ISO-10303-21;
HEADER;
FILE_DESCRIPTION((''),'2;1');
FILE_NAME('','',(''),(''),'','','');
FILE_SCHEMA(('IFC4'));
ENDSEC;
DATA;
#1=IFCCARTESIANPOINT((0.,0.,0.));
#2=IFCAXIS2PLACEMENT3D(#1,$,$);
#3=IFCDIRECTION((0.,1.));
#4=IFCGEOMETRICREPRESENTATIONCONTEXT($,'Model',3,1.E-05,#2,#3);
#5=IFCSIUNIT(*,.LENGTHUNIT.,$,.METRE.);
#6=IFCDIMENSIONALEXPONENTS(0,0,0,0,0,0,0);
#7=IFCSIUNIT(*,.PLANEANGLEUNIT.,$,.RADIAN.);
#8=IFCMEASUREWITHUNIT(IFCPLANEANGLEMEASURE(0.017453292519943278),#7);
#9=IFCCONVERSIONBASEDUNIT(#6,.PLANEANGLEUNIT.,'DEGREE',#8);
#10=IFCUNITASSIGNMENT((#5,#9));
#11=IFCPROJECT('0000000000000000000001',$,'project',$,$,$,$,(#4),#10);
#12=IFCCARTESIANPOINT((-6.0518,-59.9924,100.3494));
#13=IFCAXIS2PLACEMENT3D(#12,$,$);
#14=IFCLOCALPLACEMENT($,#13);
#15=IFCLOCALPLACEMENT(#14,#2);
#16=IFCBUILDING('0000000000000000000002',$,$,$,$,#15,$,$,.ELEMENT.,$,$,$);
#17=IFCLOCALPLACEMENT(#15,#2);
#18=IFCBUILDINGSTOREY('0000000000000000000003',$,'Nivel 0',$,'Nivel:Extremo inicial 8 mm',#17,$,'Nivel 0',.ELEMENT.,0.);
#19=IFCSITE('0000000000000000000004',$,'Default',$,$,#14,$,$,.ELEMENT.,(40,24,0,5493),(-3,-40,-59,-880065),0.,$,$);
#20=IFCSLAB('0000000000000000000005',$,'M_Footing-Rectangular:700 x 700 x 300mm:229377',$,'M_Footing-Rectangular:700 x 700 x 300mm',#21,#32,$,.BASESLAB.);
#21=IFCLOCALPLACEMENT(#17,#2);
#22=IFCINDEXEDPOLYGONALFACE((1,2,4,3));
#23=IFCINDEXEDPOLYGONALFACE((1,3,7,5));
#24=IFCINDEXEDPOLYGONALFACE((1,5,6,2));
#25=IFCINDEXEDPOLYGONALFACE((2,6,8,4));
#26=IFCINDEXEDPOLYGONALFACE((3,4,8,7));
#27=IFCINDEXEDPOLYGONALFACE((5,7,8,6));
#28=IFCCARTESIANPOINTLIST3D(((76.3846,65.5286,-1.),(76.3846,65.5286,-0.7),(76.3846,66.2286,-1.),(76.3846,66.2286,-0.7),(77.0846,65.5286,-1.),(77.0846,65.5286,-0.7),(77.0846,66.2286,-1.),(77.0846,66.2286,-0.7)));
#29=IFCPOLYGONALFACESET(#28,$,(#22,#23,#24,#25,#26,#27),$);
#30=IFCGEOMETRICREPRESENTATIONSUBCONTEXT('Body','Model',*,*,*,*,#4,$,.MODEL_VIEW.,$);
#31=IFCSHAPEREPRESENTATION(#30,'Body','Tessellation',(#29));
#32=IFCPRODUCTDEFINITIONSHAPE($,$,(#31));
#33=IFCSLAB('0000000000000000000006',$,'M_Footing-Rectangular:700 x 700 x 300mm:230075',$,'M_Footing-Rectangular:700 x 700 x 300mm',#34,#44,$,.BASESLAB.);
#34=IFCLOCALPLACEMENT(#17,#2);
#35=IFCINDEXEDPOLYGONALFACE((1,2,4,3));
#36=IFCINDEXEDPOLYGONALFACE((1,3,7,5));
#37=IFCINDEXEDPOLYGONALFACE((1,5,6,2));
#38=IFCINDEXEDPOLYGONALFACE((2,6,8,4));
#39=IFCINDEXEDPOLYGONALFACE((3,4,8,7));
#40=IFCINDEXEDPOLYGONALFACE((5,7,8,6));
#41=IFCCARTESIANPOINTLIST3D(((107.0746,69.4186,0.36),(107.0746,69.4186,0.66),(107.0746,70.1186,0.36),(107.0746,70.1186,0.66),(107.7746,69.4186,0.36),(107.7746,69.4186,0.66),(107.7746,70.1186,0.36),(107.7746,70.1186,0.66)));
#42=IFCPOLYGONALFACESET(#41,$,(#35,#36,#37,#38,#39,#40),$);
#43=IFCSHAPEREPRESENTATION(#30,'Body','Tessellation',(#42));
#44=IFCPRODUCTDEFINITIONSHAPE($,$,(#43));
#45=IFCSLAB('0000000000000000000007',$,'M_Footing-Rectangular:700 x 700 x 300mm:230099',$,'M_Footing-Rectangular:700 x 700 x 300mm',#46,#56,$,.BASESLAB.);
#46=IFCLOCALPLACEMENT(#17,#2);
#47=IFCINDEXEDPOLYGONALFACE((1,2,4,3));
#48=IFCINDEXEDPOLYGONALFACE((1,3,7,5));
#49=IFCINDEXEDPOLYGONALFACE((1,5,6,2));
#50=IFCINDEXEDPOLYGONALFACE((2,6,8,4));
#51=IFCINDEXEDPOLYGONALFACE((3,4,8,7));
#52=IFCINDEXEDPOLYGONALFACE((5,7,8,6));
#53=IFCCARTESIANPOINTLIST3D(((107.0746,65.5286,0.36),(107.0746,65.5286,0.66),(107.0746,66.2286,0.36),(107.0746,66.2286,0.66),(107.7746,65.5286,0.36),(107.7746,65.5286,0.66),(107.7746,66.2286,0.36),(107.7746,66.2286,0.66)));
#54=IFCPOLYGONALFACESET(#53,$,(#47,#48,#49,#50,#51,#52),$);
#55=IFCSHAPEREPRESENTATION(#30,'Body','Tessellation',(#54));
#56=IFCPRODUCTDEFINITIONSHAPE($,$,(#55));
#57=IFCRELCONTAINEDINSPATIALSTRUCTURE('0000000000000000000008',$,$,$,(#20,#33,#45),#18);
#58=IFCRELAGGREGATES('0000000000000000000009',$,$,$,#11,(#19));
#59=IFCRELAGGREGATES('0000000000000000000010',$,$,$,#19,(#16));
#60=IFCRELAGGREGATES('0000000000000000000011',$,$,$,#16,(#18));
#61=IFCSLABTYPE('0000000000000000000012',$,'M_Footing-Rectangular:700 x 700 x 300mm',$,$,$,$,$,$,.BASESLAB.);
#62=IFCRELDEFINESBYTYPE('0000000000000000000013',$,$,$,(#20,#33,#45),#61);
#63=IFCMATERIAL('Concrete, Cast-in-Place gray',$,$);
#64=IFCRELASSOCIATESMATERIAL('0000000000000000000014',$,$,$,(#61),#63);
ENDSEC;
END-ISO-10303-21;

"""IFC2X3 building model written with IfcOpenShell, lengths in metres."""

from ifc_helpers import new_model, entity, si_unit, converted_unit, direction, frame, frame_2d, origin, place, context, subcontext, project, spatial, rectangle, extrude, material, type_object, element, save


model = new_model("IFC2X3")

# Units and contexts
model_context = context("Model", 3, precision=1e-05, world=origin(), true_north=direction((0.0, 1.0)))
body_context = subcontext(model_context, "Body", "Model", "MODEL_VIEW")
ifc_project = project(units=[si_unit("LENGTHUNIT", "METRE"), converted_unit("PLANEANGLEUNIT", "DEGREE", entity("IfcPlaneAngleMeasure", 0.017453292519943278), si_unit("PLANEANGLEUNIT", "RADIAN"), dimensions=[0, 0, 0, 0, 0, 0, 0])], contexts=[model_context])

# Site, building, storey
site_placement = place(None, frame((-6.0518, -59.9924, 100.3494)))
site = spatial("IfcSite", under=ifc_project, at=site_placement, Name="Default", CompositionType="ELEMENT", RefLatitude=(40, 24, 0, 5493), RefLongitude=(-3, -40, -59, -880065), RefElevation=0.0)
building_placement = place(site_placement, origin())
building = spatial("IfcBuilding", under=site, at=building_placement, CompositionType="ELEMENT")
storey_placement = place(building_placement, origin())
storey = spatial("IfcBuildingStorey", under=building, at=storey_placement, Name="Nivel 0", ObjectType="Nivel:Extremo inicial 8 mm", LongName="Nivel 0", CompositionType="ELEMENT", Elevation=0.0)

# Shared definitions
ifc_material = material(Name="Concrete, Cast-in-Place gray")

# Slabs
slab_type_1 = type_object("IfcSlabType", Name="M_Footing-Rectangular:700 x 700 x 300mm", PredefinedType="BASESLAB", material=ifc_material)
slab_1_placement = place(storey_placement, origin())
element("IfcSlab", 1, at=slab_1_placement, inside=storey, type_object=slab_type_1, Name="M_Footing-Rectangular:700 x 700 x 300mm:229377", ObjectType="M_Footing-Rectangular:700 x 700 x 300mm", PredefinedType="BASESLAB", context=body_context, shape_type="SweptSolid", body=[
    extrude(rectangle(XDim=0.7, YDim=0.7, at=frame_2d((0.0, 0.0), x_axis=(1.0, 0.0))), frame((76.7346, 65.8786, -1.0), z_axis=(0.0, 0.0, 1.0), x_axis=(-1.0, 0.0, 0.0)), (0.0, 0.0, 1.0), 0.3),
])
slab_2_placement = place(storey_placement, origin())
element("IfcSlab", 2, at=slab_2_placement, inside=storey, type_object=slab_type_1, Name="M_Footing-Rectangular:700 x 700 x 300mm:230075", ObjectType="M_Footing-Rectangular:700 x 700 x 300mm", PredefinedType="BASESLAB", context=body_context, shape_type="SweptSolid", body=[
    extrude(rectangle(XDim=0.7, YDim=0.7, at=frame_2d((0.0, 0.0), x_axis=(1.0, 0.0))), frame((107.4246, 69.7686, 0.36), z_axis=(0.0, 0.0, 1.0), x_axis=(-1.0, 0.0, 0.0)), (0.0, 0.0, 1.0), 0.3),
])
slab_3_placement = place(storey_placement, origin())
element("IfcSlab", 3, at=slab_3_placement, inside=storey, type_object=slab_type_1, Name="M_Footing-Rectangular:700 x 700 x 300mm:230099", ObjectType="M_Footing-Rectangular:700 x 700 x 300mm", PredefinedType="BASESLAB", context=body_context, shape_type="SweptSolid", body=[
    extrude(rectangle(XDim=0.7, YDim=0.7, at=frame_2d((0.0, 0.0), x_axis=(1.0, 0.0))), frame((107.4246, 65.8786, 0.36), z_axis=(0.0, 0.0, 1.0), x_axis=(-1.0, 0.0, 0.0)), (0.0, 0.0, 1.0), 0.3),
])

save(model, "model.ifc")
